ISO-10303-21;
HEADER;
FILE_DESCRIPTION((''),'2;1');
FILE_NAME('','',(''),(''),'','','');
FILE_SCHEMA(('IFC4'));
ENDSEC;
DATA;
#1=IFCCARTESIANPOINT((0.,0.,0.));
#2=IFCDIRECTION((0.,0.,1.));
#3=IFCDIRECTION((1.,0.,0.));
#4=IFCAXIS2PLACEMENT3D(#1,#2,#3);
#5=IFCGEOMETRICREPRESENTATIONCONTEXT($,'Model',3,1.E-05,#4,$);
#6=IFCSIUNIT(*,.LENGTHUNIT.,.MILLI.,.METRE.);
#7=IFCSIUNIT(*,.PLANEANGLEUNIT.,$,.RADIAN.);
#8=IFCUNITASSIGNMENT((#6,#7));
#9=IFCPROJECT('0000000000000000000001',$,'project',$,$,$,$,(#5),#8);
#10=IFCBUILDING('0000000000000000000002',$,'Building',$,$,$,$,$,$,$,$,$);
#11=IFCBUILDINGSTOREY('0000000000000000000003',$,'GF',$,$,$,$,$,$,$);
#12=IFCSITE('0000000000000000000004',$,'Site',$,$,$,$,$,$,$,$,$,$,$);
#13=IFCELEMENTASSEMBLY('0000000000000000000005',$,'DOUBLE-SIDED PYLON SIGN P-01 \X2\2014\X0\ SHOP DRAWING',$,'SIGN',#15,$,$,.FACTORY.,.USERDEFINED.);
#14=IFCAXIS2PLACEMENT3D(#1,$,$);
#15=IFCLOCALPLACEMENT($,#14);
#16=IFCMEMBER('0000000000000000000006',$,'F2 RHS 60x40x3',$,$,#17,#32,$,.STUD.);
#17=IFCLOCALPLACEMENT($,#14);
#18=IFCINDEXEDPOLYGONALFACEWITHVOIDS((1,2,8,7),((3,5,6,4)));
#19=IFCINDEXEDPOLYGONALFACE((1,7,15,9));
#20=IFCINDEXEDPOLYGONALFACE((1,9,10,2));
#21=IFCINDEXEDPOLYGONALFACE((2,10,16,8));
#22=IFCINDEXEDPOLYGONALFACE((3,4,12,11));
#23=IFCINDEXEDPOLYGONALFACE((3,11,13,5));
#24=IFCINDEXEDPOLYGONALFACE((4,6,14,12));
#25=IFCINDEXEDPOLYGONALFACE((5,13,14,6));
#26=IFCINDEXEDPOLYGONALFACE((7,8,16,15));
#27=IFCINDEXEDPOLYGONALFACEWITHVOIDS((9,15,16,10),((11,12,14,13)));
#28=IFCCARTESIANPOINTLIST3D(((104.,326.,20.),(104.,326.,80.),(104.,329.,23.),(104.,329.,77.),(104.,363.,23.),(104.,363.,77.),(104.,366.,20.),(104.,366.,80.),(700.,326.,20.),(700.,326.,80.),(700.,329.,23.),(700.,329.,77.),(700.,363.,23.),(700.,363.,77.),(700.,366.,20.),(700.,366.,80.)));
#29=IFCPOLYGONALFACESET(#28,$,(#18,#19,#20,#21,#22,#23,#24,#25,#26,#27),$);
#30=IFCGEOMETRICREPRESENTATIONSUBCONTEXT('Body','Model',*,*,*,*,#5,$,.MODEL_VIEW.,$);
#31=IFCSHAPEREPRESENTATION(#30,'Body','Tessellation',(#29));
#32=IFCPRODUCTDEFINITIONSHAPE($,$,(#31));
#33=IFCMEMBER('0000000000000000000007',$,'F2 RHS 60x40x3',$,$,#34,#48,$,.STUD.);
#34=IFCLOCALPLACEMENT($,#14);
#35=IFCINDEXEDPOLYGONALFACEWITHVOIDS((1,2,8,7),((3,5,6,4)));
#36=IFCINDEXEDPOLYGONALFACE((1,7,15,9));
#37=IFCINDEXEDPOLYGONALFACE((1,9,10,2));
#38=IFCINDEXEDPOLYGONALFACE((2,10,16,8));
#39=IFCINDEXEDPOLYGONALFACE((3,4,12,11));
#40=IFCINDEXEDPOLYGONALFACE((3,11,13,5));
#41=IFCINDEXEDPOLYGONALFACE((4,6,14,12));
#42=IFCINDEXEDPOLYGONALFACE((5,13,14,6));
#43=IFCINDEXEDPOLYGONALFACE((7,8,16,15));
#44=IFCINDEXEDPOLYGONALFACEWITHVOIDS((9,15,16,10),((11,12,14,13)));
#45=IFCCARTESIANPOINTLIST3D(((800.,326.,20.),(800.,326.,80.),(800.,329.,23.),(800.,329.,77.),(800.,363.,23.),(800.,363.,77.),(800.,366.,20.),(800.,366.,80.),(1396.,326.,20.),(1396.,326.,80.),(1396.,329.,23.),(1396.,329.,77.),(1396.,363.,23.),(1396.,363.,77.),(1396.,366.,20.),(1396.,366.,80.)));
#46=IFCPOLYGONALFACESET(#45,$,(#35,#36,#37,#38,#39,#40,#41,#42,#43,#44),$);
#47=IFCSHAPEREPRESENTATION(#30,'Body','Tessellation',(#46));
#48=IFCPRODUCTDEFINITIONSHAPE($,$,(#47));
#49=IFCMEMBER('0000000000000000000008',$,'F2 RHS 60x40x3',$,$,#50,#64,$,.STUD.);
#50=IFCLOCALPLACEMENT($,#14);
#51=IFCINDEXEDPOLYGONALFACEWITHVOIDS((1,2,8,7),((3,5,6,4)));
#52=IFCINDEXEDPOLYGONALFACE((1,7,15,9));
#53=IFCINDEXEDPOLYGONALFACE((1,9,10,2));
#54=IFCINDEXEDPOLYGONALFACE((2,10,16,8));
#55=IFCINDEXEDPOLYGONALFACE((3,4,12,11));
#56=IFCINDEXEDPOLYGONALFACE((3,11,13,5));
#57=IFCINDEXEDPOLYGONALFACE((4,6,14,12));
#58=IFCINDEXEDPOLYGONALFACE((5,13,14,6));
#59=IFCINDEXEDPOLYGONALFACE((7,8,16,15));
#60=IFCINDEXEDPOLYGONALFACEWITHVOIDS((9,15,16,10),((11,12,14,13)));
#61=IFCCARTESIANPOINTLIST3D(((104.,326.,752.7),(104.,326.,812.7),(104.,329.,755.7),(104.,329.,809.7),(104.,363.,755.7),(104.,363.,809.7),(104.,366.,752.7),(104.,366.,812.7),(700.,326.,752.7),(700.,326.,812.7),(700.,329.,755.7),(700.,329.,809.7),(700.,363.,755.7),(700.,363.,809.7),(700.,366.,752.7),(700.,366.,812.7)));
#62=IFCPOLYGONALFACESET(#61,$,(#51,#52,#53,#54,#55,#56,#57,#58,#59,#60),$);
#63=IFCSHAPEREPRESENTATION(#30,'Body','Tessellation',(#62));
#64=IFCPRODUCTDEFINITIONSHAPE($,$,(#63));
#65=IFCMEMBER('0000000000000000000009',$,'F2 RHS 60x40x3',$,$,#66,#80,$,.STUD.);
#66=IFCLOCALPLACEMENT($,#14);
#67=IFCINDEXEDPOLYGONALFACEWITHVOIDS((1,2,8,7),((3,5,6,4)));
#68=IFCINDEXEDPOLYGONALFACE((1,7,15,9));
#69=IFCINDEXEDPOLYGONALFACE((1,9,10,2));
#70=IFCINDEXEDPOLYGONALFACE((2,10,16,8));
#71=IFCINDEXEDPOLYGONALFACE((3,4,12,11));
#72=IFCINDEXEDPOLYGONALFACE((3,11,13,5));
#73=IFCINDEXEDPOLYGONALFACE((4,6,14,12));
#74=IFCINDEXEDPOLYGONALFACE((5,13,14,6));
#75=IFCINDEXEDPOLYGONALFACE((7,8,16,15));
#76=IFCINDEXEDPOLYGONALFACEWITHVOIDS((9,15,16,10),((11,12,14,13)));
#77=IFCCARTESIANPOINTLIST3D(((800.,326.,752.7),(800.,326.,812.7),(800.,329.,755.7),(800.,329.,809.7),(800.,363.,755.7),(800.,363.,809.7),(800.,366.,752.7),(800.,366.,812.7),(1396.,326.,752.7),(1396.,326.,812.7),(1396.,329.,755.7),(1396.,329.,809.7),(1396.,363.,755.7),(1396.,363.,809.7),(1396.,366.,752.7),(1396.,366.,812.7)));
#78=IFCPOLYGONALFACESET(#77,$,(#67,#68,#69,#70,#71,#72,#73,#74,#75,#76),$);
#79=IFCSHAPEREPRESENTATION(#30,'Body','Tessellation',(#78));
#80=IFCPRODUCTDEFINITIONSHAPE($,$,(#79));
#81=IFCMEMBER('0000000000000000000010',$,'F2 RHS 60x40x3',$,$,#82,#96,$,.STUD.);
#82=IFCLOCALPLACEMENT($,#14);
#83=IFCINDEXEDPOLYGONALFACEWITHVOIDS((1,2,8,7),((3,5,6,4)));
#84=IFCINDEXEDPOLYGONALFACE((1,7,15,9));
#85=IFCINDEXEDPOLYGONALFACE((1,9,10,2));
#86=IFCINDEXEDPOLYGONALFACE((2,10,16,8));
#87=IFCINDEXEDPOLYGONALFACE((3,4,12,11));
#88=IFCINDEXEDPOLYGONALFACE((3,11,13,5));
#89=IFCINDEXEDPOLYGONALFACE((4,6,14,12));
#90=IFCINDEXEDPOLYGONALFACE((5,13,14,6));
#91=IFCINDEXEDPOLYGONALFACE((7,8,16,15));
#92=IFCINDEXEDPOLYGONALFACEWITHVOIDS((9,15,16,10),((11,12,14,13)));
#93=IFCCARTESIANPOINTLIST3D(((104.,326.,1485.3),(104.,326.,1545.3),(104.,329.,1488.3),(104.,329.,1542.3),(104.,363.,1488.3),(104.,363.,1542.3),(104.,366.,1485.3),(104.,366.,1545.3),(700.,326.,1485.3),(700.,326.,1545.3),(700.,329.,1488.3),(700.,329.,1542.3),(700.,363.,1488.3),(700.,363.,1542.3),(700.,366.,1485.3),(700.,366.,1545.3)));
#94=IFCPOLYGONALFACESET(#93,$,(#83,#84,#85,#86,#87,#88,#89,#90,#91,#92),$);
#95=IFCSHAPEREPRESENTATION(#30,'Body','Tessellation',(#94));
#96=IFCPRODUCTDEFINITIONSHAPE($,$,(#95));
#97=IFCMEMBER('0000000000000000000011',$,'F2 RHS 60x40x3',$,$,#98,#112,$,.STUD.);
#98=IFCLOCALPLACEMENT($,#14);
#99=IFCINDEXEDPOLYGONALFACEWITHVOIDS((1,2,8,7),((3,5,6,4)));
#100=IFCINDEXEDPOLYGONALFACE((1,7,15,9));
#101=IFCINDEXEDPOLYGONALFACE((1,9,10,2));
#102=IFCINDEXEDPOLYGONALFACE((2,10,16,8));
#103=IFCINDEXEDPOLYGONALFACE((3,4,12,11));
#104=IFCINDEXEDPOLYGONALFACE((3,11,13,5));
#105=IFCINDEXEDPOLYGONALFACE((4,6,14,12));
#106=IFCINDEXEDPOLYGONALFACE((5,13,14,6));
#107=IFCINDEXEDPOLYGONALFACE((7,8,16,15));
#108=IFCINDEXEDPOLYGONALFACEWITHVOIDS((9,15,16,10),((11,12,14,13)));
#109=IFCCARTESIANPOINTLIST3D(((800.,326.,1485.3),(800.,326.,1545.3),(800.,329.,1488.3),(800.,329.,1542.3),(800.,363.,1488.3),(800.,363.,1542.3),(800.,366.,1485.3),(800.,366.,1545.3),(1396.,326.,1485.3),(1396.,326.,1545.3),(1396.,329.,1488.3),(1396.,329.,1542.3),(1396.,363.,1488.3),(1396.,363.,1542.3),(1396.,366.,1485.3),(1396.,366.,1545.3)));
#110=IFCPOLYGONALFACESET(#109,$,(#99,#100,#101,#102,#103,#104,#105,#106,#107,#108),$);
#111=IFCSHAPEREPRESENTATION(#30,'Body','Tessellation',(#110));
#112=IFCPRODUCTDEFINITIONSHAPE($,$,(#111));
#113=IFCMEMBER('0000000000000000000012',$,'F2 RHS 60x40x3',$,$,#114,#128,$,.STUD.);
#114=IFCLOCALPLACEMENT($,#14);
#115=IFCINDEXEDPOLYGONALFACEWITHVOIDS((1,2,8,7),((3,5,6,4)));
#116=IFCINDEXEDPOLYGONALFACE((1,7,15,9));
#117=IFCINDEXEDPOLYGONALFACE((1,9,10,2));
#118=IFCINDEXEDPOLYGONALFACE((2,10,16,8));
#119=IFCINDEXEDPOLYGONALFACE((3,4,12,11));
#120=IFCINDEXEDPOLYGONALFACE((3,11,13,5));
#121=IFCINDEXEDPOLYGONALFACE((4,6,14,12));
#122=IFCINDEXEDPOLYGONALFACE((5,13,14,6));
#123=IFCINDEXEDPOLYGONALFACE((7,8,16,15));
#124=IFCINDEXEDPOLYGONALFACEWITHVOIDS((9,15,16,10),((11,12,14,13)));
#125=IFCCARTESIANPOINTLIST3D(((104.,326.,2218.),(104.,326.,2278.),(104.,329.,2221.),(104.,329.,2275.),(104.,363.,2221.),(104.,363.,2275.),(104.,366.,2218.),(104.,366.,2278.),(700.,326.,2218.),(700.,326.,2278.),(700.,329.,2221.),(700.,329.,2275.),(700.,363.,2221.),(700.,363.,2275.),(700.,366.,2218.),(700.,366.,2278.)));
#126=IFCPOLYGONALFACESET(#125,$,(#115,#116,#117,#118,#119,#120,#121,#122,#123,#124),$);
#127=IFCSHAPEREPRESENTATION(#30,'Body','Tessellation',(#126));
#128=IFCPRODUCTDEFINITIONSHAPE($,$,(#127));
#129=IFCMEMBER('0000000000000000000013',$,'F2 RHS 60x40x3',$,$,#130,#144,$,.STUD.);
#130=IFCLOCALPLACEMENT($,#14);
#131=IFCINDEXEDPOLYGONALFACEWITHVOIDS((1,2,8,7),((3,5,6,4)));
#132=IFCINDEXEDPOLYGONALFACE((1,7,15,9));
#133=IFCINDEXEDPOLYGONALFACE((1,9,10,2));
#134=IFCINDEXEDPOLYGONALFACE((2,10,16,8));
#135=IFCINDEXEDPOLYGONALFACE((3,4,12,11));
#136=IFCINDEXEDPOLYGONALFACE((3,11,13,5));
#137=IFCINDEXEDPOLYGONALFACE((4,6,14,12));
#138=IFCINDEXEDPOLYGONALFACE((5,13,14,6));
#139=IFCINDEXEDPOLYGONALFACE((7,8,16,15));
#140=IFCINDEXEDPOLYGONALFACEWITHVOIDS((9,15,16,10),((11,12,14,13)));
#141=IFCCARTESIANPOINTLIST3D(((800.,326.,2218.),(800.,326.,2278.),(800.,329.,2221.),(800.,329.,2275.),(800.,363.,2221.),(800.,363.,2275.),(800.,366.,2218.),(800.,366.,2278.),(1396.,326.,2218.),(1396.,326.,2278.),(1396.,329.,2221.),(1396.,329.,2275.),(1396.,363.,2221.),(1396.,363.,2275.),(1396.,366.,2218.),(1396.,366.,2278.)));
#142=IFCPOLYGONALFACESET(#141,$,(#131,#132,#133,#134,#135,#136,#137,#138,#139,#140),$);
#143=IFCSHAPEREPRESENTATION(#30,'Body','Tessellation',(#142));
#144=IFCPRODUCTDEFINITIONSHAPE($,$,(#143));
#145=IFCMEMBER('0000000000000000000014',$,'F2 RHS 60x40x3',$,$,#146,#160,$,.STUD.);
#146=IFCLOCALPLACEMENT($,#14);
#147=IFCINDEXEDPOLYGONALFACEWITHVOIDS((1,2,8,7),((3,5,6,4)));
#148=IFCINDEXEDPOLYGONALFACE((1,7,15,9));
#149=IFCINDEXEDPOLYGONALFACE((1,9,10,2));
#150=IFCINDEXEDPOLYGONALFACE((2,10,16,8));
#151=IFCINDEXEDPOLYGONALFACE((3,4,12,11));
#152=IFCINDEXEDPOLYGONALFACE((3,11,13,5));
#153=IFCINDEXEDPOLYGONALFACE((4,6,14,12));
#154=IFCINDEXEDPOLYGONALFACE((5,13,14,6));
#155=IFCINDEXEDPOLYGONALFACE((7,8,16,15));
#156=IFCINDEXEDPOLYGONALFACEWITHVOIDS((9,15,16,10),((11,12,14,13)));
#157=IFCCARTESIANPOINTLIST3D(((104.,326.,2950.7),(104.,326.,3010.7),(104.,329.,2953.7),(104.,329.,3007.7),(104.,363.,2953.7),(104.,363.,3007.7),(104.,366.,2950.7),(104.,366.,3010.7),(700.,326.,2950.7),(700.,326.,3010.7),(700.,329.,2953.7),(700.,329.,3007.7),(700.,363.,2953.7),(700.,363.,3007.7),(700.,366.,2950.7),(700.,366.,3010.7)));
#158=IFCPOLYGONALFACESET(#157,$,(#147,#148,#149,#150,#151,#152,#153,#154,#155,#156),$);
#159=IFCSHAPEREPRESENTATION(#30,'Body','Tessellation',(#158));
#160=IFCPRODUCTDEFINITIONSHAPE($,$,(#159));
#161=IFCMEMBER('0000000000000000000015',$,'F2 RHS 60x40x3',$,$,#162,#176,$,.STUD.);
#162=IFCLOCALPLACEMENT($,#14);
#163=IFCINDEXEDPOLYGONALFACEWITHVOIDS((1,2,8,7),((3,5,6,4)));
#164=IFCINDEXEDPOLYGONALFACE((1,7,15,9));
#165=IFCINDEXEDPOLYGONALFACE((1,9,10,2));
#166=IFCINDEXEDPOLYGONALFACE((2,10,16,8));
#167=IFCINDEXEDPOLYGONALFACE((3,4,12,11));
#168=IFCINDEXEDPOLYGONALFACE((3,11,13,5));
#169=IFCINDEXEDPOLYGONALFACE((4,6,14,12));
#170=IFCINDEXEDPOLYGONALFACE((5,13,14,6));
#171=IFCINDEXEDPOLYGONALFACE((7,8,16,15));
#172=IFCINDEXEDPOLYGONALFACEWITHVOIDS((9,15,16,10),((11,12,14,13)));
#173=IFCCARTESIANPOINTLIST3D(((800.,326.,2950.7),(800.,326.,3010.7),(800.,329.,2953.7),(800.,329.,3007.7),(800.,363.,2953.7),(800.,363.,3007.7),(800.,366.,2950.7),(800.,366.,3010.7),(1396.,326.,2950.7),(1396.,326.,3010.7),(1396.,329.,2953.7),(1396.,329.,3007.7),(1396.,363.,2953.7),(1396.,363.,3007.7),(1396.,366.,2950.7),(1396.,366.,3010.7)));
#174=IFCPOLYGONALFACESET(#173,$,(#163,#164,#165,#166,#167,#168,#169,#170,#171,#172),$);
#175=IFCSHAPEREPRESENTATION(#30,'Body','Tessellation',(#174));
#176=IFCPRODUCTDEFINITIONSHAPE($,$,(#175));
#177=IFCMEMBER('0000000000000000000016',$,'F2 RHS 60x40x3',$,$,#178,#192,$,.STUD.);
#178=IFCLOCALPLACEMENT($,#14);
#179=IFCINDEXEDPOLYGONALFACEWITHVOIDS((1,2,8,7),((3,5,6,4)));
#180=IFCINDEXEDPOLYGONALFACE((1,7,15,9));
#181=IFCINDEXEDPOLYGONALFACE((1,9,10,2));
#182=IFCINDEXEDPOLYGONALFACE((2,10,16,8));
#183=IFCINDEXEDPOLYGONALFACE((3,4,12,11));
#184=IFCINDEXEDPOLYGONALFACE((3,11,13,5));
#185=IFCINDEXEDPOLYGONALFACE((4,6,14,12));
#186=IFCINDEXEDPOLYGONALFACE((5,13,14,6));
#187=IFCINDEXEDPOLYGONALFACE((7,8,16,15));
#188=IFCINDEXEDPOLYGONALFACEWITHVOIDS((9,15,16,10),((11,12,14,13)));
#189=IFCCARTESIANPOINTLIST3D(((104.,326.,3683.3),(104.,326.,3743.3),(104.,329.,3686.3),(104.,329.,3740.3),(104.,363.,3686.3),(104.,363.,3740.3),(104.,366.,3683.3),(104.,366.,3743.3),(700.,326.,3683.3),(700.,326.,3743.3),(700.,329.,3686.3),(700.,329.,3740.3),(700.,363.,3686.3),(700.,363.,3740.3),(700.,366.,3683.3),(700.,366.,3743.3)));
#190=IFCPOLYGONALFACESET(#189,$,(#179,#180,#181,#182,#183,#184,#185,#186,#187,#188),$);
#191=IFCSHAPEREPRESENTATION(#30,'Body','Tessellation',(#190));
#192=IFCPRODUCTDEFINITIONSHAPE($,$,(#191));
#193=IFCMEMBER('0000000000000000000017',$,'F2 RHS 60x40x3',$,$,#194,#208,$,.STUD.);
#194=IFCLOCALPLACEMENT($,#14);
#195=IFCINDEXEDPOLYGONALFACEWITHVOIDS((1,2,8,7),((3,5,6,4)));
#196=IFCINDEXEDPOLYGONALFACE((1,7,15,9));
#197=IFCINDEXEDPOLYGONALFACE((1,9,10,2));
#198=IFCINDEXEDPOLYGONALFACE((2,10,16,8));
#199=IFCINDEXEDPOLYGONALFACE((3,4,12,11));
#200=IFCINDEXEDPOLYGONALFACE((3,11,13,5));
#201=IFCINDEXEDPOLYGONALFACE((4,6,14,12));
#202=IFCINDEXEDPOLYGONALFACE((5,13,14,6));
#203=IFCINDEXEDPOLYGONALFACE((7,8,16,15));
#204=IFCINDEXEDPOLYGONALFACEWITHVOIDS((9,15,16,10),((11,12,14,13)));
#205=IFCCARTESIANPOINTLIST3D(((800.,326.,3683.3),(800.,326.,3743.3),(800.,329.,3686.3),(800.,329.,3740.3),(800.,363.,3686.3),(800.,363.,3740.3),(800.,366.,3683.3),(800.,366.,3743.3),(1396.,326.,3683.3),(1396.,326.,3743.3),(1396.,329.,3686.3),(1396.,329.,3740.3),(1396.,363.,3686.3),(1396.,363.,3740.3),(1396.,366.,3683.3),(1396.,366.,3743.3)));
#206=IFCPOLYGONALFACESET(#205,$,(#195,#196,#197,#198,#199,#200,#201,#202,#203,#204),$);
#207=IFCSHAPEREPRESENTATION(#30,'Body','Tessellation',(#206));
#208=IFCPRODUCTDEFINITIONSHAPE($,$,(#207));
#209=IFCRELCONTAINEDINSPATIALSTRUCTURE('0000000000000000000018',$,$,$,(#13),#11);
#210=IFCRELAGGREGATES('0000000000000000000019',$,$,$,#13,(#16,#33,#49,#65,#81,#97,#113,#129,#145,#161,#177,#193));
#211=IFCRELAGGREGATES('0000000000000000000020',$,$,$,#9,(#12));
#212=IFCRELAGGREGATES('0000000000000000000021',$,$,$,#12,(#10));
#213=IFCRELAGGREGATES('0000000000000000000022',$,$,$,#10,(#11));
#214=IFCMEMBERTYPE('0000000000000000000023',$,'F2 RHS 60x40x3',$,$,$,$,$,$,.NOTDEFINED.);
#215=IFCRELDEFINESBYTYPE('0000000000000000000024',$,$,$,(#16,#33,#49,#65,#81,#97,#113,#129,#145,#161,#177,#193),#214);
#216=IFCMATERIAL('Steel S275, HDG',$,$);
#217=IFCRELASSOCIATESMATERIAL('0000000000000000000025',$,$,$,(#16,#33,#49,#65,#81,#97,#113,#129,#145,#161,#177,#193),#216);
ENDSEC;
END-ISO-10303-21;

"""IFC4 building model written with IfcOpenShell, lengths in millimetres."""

from ifc_helpers import new_model, si_unit, frame, origin, origin_with_axes, place, context, subcontext, project, spatial, hollow_rectangle, extrude, material, type_object, element, aggregate, save


model = new_model("IFC4")

# Units and contexts
model_context = context("Model", 3, precision=1e-05, world=origin_with_axes())
body_context = subcontext(model_context, "Body", "Model", "MODEL_VIEW")
ifc_project = project(units=[si_unit("LENGTHUNIT", "METRE", prefix="MILLI"), si_unit("PLANEANGLEUNIT", "RADIAN")], contexts=[model_context])

# Site, building, storey
site = spatial("IfcSite", under=ifc_project, Name="Site")
building = spatial("IfcBuilding", under=site, Name="Building")
storey = spatial("IfcBuildingStorey", under=building, Name="GF")

# Element assembly, members
assembly_placement = place(None, origin_with_axes())
assembly = element("IfcElementAssembly", 1, at=assembly_placement, inside=storey, Name="DOUBLE-SIDED PYLON SIGN P-01 — SHOP DRAWING", ObjectType="SIGN", AssemblyPlace="FACTORY", PredefinedType="USERDEFINED")
ifc_material_1 = material(Name="Steel S275, HDG")
member_type = type_object("IfcMemberType", Name="F2 RHS 60x40x3", PredefinedType="NOTDEFINED")
member_1_placement = place(assembly_placement, frame((104.0, 346.0, 50.0), z_axis=(1.0, 0.0, 0.0), x_axis=(0.0, 0.0, 1.0)))
member_1 = element("IfcMember", 2, at=member_1_placement, type_object=member_type, material=ifc_material_1, Name="F2 RHS 60x40x3", PredefinedType="STUD", context=body_context, shape_type="SweptSolid", body=[
    extrude(hollow_rectangle(XDim=60.0, YDim=40.0, WallThickness=3.0), origin(), (0.0, 0.0, 1.0), 596.0),
])
member_2_placement = place(assembly_placement, frame((800.0, 346.0, 50.0), z_axis=(1.0, 0.0, 0.0), x_axis=(0.0, 0.0, 1.0)))
member_2 = element("IfcMember", 3, at=member_2_placement, type_object=member_type, material=ifc_material_1, Name="F2 RHS 60x40x3", PredefinedType="STUD", context=body_context, shape_type="SweptSolid", body=[
    extrude(hollow_rectangle(XDim=60.0, YDim=40.0, WallThickness=3.0), origin(), (0.0, 0.0, 1.0), 596.0),
])
member_3_placement = place(assembly_placement, frame((104.0, 346.0, 782.7), z_axis=(1.0, 0.0, 0.0), x_axis=(0.0, 0.0, 1.0)))
member_3 = element("IfcMember", 4, at=member_3_placement, type_object=member_type, material=ifc_material_1, Name="F2 RHS 60x40x3", PredefinedType="STUD", context=body_context, shape_type="SweptSolid", body=[
    extrude(hollow_rectangle(XDim=60.0, YDim=40.0, WallThickness=3.0), origin(), (0.0, 0.0, 1.0), 596.0),
])
member_4_placement = place(assembly_placement, frame((800.0, 346.0, 782.7), z_axis=(1.0, 0.0, 0.0), x_axis=(0.0, 0.0, 1.0)))
member_4 = element("IfcMember", 5, at=member_4_placement, type_object=member_type, material=ifc_material_1, Name="F2 RHS 60x40x3", PredefinedType="STUD", context=body_context, shape_type="SweptSolid", body=[
    extrude(hollow_rectangle(XDim=60.0, YDim=40.0, WallThickness=3.0), origin(), (0.0, 0.0, 1.0), 596.0),
])
member_5_placement = place(assembly_placement, frame((104.0, 346.0, 1515.3), z_axis=(1.0, 0.0, 0.0), x_axis=(0.0, 0.0, 1.0)))
member_5 = element("IfcMember", 6, at=member_5_placement, type_object=member_type, material=ifc_material_1, Name="F2 RHS 60x40x3", PredefinedType="STUD", context=body_context, shape_type="SweptSolid", body=[
    extrude(hollow_rectangle(XDim=60.0, YDim=40.0, WallThickness=3.0), origin(), (0.0, 0.0, 1.0), 596.0),
])
member_6_placement = place(assembly_placement, frame((800.0, 346.0, 1515.3), z_axis=(1.0, 0.0, 0.0), x_axis=(0.0, 0.0, 1.0)))
member_6 = element("IfcMember", 7, at=member_6_placement, type_object=member_type, material=ifc_material_1, Name="F2 RHS 60x40x3", PredefinedType="STUD", context=body_context, shape_type="SweptSolid", body=[
    extrude(hollow_rectangle(XDim=60.0, YDim=40.0, WallThickness=3.0), origin(), (0.0, 0.0, 1.0), 596.0),
])
member_7_placement = place(assembly_placement, frame((104.0, 346.0, 2248.0), z_axis=(1.0, 0.0, 0.0), x_axis=(0.0, 0.0, 1.0)))
member_7 = element("IfcMember", 8, at=member_7_placement, type_object=member_type, material=ifc_material_1, Name="F2 RHS 60x40x3", PredefinedType="STUD", context=body_context, shape_type="SweptSolid", body=[
    extrude(hollow_rectangle(XDim=60.0, YDim=40.0, WallThickness=3.0), origin(), (0.0, 0.0, 1.0), 596.0),
])
member_8_placement = place(assembly_placement, frame((800.0, 346.0, 2248.0), z_axis=(1.0, 0.0, 0.0), x_axis=(0.0, 0.0, 1.0)))
member_8 = element("IfcMember", 9, at=member_8_placement, type_object=member_type, material=ifc_material_1, Name="F2 RHS 60x40x3", PredefinedType="STUD", context=body_context, shape_type="SweptSolid", body=[
    extrude(hollow_rectangle(XDim=60.0, YDim=40.0, WallThickness=3.0), origin(), (0.0, 0.0, 1.0), 596.0),
])
member_9_placement = place(assembly_placement, frame((104.0, 346.0, 2980.7), z_axis=(1.0, 0.0, 0.0), x_axis=(0.0, 0.0, 1.0)))
member_9 = element("IfcMember", 10, at=member_9_placement, type_object=member_type, material=ifc_material_1, Name="F2 RHS 60x40x3", PredefinedType="STUD", context=body_context, shape_type="SweptSolid", body=[
    extrude(hollow_rectangle(XDim=60.0, YDim=40.0, WallThickness=3.0), origin(), (0.0, 0.0, 1.0), 596.0),
])
member_10_placement = place(assembly_placement, frame((800.0, 346.0, 2980.7), z_axis=(1.0, 0.0, 0.0), x_axis=(0.0, 0.0, 1.0)))
member_10 = element("IfcMember", 11, at=member_10_placement, type_object=member_type, material=ifc_material_1, Name="F2 RHS 60x40x3", PredefinedType="STUD", context=body_context, shape_type="SweptSolid", body=[
    extrude(hollow_rectangle(XDim=60.0, YDim=40.0, WallThickness=3.0), origin(), (0.0, 0.0, 1.0), 596.0),
])
member_11_placement = place(assembly_placement, frame((104.0, 346.0, 3713.3), z_axis=(1.0, 0.0, 0.0), x_axis=(0.0, 0.0, 1.0)))
member_11 = element("IfcMember", 12, at=member_11_placement, type_object=member_type, material=ifc_material_1, Name="F2 RHS 60x40x3", PredefinedType="STUD", context=body_context, shape_type="SweptSolid", body=[
    extrude(hollow_rectangle(XDim=60.0, YDim=40.0, WallThickness=3.0), origin(), (0.0, 0.0, 1.0), 596.0),
])
member_12_placement = place(assembly_placement, frame((800.0, 346.0, 3713.3), z_axis=(1.0, 0.0, 0.0), x_axis=(0.0, 0.0, 1.0)))
member_12 = element("IfcMember", 13, at=member_12_placement, type_object=member_type, material=ifc_material_1, Name="F2 RHS 60x40x3", PredefinedType="STUD", context=body_context, shape_type="SweptSolid", body=[
    extrude(hollow_rectangle(XDim=60.0, YDim=40.0, WallThickness=3.0), origin(), (0.0, 0.0, 1.0), 596.0),
])
aggregate(assembly, [member_1, member_2, member_3, member_4, member_5, member_6, member_7, member_8, member_9, member_10, member_11, member_12])

save(model, "model.ifc")
